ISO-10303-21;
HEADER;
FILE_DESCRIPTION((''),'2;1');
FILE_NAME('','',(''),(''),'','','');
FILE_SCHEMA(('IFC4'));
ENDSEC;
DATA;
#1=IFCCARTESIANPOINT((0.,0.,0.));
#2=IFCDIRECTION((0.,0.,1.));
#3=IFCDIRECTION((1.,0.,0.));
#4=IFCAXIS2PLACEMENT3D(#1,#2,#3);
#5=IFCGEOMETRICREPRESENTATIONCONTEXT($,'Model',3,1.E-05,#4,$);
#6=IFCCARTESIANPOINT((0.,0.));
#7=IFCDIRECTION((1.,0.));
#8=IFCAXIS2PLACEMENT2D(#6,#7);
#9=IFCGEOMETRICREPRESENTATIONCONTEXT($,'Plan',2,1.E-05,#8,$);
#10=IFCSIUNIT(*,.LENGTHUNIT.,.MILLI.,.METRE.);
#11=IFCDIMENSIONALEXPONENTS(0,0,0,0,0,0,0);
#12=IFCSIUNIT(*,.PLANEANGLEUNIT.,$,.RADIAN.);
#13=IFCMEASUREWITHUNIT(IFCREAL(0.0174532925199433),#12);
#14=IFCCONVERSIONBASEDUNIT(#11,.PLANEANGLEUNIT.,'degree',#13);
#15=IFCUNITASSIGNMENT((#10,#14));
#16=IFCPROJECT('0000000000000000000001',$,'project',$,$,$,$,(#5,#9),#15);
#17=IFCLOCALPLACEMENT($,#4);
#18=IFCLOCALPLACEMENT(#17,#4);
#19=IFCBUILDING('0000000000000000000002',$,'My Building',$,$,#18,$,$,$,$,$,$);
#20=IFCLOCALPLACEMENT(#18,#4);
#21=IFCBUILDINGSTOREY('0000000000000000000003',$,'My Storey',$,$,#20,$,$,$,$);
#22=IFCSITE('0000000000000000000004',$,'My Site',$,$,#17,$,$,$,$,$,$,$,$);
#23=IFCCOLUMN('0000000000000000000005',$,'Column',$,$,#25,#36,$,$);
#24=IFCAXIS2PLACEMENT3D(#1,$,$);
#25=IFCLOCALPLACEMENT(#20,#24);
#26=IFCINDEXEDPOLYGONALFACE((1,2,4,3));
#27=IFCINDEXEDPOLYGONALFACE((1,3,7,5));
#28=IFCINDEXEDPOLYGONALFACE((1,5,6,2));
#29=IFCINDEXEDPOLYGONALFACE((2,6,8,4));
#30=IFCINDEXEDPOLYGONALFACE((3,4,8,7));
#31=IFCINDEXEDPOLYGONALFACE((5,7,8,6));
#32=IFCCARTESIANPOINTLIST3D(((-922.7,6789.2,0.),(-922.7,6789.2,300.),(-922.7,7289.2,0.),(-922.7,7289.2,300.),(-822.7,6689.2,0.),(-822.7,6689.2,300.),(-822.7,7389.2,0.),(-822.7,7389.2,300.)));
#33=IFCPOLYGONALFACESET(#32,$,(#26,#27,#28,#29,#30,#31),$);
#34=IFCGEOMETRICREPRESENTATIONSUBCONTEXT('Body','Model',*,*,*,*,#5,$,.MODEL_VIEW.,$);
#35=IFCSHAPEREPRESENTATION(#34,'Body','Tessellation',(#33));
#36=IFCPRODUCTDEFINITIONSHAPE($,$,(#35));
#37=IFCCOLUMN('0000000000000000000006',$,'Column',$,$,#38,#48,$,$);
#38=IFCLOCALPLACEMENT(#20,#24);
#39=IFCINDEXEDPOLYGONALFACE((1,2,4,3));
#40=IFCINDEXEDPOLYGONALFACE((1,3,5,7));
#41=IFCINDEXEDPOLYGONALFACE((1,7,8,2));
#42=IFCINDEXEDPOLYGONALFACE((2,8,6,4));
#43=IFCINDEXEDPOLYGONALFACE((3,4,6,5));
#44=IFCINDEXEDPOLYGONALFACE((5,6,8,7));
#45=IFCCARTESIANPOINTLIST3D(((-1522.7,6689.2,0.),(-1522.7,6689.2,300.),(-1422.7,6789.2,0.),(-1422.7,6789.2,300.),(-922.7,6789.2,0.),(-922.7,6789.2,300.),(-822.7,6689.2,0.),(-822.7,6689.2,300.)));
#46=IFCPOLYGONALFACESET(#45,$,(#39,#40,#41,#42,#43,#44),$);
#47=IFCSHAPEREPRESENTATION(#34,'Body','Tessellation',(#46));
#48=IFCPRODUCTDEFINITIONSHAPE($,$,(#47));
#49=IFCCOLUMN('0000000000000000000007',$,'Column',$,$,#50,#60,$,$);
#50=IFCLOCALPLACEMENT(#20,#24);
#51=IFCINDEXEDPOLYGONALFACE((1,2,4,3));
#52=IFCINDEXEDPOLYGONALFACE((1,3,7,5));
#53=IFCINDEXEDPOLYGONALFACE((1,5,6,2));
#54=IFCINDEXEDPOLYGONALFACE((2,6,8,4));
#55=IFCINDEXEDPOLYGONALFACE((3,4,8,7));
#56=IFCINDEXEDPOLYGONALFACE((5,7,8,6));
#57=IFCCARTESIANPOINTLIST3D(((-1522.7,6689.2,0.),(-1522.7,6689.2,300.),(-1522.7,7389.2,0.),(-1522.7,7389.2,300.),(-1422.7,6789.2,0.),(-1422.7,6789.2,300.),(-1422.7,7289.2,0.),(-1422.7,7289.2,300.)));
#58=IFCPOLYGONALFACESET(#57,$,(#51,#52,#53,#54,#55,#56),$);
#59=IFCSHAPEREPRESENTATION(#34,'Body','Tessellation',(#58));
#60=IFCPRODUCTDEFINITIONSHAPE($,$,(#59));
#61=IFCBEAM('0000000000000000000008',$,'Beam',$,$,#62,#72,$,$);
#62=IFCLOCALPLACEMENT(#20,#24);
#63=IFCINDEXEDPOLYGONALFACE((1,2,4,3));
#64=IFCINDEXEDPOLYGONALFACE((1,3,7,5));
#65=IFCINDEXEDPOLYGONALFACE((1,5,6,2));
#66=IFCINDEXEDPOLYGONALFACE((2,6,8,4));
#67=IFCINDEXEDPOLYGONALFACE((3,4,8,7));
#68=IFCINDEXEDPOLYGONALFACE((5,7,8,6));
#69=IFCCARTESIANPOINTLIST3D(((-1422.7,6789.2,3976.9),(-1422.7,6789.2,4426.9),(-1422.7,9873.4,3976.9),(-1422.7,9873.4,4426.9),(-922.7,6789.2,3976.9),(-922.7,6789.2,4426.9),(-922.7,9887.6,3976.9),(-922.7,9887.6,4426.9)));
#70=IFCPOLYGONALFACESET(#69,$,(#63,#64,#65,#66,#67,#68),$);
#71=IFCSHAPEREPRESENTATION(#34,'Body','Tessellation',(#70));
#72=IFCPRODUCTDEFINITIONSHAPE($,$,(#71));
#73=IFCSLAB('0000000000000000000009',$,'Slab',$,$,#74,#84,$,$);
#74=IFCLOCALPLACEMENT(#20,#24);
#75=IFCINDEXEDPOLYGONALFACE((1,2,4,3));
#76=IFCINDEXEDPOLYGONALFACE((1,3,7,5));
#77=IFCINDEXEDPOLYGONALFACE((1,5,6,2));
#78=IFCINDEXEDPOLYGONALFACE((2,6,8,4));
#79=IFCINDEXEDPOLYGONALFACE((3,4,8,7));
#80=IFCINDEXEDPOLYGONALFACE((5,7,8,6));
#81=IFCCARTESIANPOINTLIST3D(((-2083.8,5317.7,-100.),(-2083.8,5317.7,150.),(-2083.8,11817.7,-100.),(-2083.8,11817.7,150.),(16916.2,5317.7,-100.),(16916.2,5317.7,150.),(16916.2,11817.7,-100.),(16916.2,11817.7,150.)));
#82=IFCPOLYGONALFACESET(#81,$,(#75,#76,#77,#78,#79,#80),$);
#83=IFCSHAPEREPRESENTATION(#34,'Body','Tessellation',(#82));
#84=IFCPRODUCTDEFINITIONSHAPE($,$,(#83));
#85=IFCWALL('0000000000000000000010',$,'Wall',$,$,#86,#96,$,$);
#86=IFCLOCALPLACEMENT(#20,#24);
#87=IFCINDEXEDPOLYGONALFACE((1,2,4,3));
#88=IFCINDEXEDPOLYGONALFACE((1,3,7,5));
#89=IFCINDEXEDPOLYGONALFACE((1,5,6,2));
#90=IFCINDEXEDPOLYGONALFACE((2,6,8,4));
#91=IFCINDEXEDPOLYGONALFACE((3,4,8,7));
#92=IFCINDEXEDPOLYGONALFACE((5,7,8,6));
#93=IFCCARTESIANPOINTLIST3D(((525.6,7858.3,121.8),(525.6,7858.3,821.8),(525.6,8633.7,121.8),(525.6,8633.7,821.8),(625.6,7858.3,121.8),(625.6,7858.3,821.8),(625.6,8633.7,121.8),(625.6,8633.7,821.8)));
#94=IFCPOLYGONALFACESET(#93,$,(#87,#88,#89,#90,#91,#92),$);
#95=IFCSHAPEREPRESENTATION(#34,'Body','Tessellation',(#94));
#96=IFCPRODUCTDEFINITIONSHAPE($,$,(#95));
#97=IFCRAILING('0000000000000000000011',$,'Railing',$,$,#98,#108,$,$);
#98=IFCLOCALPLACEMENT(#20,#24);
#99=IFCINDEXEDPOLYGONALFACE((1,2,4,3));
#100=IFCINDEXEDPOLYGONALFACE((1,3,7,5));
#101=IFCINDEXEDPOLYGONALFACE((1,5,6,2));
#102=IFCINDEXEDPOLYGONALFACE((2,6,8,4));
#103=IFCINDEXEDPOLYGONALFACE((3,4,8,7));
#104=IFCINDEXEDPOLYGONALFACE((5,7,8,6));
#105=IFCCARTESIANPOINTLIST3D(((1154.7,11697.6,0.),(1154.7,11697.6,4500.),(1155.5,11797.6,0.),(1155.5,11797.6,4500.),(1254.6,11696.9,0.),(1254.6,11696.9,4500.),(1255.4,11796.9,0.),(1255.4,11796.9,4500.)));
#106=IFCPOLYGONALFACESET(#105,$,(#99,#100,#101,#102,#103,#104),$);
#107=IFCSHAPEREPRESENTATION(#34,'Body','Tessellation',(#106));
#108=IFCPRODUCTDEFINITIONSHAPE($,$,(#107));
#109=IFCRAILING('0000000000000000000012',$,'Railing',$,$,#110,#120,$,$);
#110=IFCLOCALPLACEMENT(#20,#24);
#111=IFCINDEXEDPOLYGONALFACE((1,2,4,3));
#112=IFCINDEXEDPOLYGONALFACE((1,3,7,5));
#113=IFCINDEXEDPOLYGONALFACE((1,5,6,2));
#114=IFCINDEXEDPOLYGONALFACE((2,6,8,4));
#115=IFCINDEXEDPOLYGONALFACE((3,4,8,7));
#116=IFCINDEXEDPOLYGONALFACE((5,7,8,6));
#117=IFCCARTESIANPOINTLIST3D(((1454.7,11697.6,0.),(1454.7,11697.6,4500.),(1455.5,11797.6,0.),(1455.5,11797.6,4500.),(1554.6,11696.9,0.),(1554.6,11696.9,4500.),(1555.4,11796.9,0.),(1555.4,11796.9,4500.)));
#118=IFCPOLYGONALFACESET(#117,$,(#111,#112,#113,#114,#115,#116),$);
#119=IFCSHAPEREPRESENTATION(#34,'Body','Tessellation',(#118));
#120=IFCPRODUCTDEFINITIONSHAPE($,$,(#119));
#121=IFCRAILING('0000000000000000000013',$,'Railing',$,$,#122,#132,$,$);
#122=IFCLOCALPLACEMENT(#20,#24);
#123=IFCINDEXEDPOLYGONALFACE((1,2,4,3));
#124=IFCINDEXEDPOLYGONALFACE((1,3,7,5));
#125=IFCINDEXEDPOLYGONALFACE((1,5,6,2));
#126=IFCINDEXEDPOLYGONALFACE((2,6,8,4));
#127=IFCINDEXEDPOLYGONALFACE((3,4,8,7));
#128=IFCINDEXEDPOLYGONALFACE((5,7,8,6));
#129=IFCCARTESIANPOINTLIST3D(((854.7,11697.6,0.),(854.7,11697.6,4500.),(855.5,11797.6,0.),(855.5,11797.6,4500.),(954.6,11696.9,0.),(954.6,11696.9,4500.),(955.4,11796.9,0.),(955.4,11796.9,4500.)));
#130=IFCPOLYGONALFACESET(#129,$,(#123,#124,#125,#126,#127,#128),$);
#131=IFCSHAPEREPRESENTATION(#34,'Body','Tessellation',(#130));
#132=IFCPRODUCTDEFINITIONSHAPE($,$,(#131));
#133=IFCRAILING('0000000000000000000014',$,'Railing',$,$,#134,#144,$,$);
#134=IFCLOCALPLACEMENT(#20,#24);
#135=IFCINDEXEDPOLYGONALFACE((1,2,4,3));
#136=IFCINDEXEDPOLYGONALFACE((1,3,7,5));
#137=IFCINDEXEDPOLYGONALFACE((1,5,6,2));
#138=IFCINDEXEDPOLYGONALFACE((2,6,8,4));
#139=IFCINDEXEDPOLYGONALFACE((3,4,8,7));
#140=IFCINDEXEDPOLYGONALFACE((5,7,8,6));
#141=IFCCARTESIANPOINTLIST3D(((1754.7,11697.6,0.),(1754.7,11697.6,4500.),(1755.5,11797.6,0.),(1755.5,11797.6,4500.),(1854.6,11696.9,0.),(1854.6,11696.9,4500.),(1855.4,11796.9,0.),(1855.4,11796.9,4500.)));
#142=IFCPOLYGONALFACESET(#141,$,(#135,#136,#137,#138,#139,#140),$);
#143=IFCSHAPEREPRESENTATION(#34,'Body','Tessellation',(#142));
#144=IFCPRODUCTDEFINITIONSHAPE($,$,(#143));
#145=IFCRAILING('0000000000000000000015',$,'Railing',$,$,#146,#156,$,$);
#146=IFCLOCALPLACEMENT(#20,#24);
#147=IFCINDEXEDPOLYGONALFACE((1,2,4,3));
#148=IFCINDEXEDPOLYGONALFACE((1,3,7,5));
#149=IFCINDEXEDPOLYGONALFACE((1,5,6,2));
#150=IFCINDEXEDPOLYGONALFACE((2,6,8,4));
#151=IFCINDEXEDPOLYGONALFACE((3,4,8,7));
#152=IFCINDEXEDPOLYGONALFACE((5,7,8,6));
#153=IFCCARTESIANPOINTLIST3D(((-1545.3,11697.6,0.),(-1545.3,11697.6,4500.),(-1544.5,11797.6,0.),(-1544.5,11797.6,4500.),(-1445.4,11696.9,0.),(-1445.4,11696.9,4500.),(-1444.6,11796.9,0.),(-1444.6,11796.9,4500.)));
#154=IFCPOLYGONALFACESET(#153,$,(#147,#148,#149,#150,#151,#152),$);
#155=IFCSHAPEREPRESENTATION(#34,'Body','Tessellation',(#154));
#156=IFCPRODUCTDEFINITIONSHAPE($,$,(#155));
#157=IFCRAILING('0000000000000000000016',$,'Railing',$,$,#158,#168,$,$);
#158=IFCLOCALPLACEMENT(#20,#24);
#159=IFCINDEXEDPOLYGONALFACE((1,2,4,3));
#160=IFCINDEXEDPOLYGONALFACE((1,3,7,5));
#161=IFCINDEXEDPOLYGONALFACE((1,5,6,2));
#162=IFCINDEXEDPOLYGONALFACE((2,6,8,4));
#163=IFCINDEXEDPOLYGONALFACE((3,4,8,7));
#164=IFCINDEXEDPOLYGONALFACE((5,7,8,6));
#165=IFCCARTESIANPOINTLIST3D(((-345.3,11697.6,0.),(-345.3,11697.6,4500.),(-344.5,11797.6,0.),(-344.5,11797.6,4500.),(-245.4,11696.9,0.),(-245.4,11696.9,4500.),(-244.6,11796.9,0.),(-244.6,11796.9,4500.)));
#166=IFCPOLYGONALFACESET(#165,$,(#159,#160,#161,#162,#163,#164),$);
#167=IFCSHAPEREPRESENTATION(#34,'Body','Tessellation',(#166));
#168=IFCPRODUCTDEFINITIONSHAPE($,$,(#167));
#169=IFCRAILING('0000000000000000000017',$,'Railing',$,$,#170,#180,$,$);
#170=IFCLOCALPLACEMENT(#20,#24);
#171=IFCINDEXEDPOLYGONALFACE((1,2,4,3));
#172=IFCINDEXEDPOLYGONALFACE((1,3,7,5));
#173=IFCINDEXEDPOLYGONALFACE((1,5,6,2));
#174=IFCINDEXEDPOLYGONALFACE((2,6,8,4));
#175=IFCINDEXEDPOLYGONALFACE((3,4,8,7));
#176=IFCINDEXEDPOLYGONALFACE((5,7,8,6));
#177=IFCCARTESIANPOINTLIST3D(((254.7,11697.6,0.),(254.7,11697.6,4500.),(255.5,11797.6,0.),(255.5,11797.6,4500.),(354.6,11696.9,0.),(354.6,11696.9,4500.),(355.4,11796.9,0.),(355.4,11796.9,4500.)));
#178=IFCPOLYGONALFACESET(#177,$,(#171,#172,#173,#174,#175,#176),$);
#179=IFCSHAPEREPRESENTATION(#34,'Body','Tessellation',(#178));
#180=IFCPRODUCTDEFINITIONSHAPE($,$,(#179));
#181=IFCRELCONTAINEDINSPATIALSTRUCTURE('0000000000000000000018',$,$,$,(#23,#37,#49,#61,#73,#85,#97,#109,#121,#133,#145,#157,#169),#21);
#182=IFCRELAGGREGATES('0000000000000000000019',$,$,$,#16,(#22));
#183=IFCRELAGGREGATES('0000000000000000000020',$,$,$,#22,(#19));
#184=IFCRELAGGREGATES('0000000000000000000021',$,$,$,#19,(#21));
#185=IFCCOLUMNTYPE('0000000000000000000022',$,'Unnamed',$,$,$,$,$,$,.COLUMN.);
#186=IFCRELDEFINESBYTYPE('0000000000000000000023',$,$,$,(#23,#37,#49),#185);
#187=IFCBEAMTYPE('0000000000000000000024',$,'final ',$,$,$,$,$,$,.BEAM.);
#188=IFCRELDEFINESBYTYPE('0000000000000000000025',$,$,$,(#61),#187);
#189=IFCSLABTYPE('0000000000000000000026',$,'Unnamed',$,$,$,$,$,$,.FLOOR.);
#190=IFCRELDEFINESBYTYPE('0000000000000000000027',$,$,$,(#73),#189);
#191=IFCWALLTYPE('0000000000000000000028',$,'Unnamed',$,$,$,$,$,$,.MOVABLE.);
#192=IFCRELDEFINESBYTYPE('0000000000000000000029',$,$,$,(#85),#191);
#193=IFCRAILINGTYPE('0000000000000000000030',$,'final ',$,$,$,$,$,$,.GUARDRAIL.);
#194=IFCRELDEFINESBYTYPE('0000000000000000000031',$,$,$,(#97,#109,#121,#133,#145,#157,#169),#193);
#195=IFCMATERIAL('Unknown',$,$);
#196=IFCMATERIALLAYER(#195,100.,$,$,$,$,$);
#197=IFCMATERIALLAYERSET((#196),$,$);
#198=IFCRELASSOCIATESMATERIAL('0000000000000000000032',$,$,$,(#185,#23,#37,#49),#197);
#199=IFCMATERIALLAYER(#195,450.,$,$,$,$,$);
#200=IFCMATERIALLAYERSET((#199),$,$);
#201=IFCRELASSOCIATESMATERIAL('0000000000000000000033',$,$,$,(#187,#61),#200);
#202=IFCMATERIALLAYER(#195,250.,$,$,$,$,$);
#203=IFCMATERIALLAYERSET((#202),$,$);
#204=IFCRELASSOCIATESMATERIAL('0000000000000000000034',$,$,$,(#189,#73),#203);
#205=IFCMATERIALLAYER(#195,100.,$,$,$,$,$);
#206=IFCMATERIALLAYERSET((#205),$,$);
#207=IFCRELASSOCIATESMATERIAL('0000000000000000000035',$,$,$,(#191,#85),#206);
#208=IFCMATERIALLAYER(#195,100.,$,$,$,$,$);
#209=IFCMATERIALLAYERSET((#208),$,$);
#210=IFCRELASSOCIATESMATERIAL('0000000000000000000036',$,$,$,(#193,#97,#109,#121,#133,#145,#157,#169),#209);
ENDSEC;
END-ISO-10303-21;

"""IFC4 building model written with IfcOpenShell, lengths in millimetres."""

from ifc_helpers import new_model, entity, si_unit, converted_unit, frame, origin_with_axes, origin_2d_with_axis, place, context, subcontext, project, spatial, line, indexed_curve, outline, extrude, material, layer, layer_set, layer_usage, type_object, element, save


model = new_model("IFC4")

# Units and contexts
model_context = context("Model", 3, precision=1e-05, world=origin_with_axes())
plan_context = context("Plan", 2, precision=1e-05, world=origin_2d_with_axis())
body_context = subcontext(model_context, "Body", "Model", "MODEL_VIEW")
ifc_project = project(units=[si_unit("LENGTHUNIT", "METRE", prefix="MILLI"), converted_unit("PLANEANGLEUNIT", "degree", entity("IfcReal", 0.0174532925199433), si_unit("PLANEANGLEUNIT", "RADIAN"), dimensions=[0, 0, 0, 0, 0, 0, 0])], contexts=[model_context, plan_context])

# Site, building, storey
site_placement = place(None, origin_with_axes())
site = spatial("IfcSite", under=ifc_project, at=site_placement, Name="My Site")
building_placement = place(site_placement, origin_with_axes())
building = spatial("IfcBuilding", under=site, at=building_placement, Name="My Building")
storey_placement = place(building_placement, origin_with_axes())
storey = spatial("IfcBuildingStorey", under=building, at=storey_placement, Name="My Storey")

# Columns
ifc_material = material(Name="Unknown")
ifc_layer_1 = layer(ifc_material, 100.0)
ifc_layer_set_1 = layer_set([ifc_layer_1])
column_type = type_object("IfcColumnType", Name="Unnamed", PredefinedType="COLUMN", material=ifc_layer_set_1)
ifc_layer_usage_1 = layer_usage(ifc_layer_set_1, "AXIS2", "POSITIVE", 0.0)
column_1_placement = place(storey_placement, frame((-922.7, 7289.2, 0.0), z_axis=(0.0, 0.0, 1.0), x_axis=(0.0, -1.0, 0.0)))
element("IfcColumn", 1, at=column_1_placement, inside=storey, type_object=column_type, material=ifc_layer_usage_1, Name="Column", context=body_context, shape_type="SweptSolid", body=[
    extrude(outline(indexed_curve([(0.0, 0.0), (-100.0, 100.0), (600.0, 100.0), (500.0, 0.0)], segments=[line(1, 2, 3, 4, 1)])), origin_with_axes(), (0.0, 0.0, 1.0), 300.0),
])
ifc_layer_usage_2 = layer_usage(ifc_layer_set_1, "AXIS2", "POSITIVE", 0.0)
column_2_placement = place(storey_placement, frame((-922.7, 6789.2, 0.0), z_axis=(0.0, 0.0, 1.0), x_axis=(-1.0, 0.0, 0.0)))
element("IfcColumn", 2, at=column_2_placement, inside=storey, type_object=column_type, material=ifc_layer_usage_2, Name="Column", context=body_context, shape_type="SweptSolid", body=[
    extrude(outline(indexed_curve([(0.0, 0.0), (-100.0, 100.0), (600.0, 100.0), (500.0, 0.0)], segments=[line(1, 2, 3, 4, 1)])), origin_with_axes(), (0.0, 0.0, 1.0), 300.0),
])
ifc_layer_usage_3 = layer_usage(ifc_layer_set_1, "AXIS2", "POSITIVE", 0.0)
column_3_placement = place(storey_placement, frame((-1422.7, 6789.2, 0.0), z_axis=(0.0, 0.0, 1.0), x_axis=(0.0, 1.0, 0.0)))
element("IfcColumn", 3, at=column_3_placement, inside=storey, type_object=column_type, material=ifc_layer_usage_3, Name="Column", context=body_context, shape_type="SweptSolid", body=[
    extrude(outline(indexed_curve([(0.0, 0.0), (-100.0, 100.0), (600.0, 100.0), (500.0, 0.0)], segments=[line(1, 2, 3, 4, 1)])), origin_with_axes(), (0.0, 0.0, 1.0), 300.0),
])

# Beam
ifc_layer_2 = layer(ifc_material, 450.0)
ifc_layer_set_2 = layer_set([ifc_layer_2])
ifc_layer_usage_4 = layer_usage(ifc_layer_set_2, "AXIS3", "POSITIVE", -450.0)
beam_type_1 = type_object("IfcBeamType", Name="final ", PredefinedType="BEAM", material=ifc_layer_set_2)
beam_1_placement = place(storey_placement, frame((-922.7, 9887.6, 4426.9), z_axis=(0.0, 0.0, 1.0), x_axis=(1.0, 0.0, 0.0)))
element("IfcBeam", 4, at=beam_1_placement, inside=storey, type_object=beam_type_1, material=ifc_layer_usage_4, Name="Beam", context=body_context, shape_type="SweptSolid", body=[
    extrude(outline(indexed_curve([(0.0, 0.0), (0.0, -3098.3), (-500.0, -3098.3), (-500.0, -14.2), (0.0, 0.0)])), frame((0.0, 0.0, -450.0), z_axis=(0.0, 0.0, 1.0), x_axis=(1.0, 0.0, 0.0)), (0.0, 0.0, 1.0), 450.0),
])

# Slab
ifc_layer_3 = layer(ifc_material, 250.0)
ifc_layer_set_3 = layer_set([ifc_layer_3])
slab_type = type_object("IfcSlabType", Name="Unnamed", PredefinedType="FLOOR", material=ifc_layer_set_3)
ifc_layer_usage_5 = layer_usage(ifc_layer_set_3, "AXIS3", "POSITIVE", -100.0)
slab_1_placement = place(storey_placement, frame((-2083.8, 11817.7, 0.0), z_axis=(0.0, 0.0, 1.0), x_axis=(1.0, 0.0, 0.0)))
element("IfcSlab", 5, at=slab_1_placement, inside=storey, type_object=slab_type, material=ifc_layer_usage_5, Name="Slab", context=body_context, shape_type="SweptSolid", body=[
    extrude(outline(indexed_curve([(0.0, 0.0), (19000.0, 0.0), (19000.0, -6500.0), (0.0, -6500.0), (0.0, 0.0)])), frame((0.0, 0.0, -100.0), z_axis=(0.0, 0.0, 1.0), x_axis=(1.0, 0.0, 0.0)), (0.0, 0.0, 1.0), 250.0),
])

# Wall
ifc_layer_4 = layer(ifc_material, 100.0)
ifc_layer_set_4 = layer_set([ifc_layer_4])
ifc_layer_usage_6 = layer_usage(ifc_layer_set_4, "AXIS2", "POSITIVE", 0.0)
wall_type = type_object("IfcWallType", Name="Unnamed", PredefinedType="MOVABLE", material=ifc_layer_set_4)
wall_placement = place(storey_placement, frame((525.6, 8633.7, 121.8), z_axis=(0.0, 0.0, 1.0), x_axis=(0.0, -1.0, 0.0)))
element("IfcWall", 6, at=wall_placement, inside=storey, type_object=wall_type, material=ifc_layer_usage_6, Name="Wall", context=body_context, shape_type="SweptSolid", body=[
    extrude(outline(indexed_curve([(0.0, 0.0), (0.0, 100.0), (775.4, 100.0), (775.4, 0.0)], segments=[line(1, 2, 3, 4, 1)])), origin_with_axes(), (0.0, 0.0, 1.0), 700.0),
])

# Railings
ifc_layer_5 = layer(ifc_material, 100.0)
ifc_layer_set_5 = layer_set([ifc_layer_5])
ifc_layer_usage_7 = layer_usage(ifc_layer_set_5, "AXIS2", "POSITIVE", 0.0)
railing_type = type_object("IfcRailingType", Name="final ", PredefinedType="GUARDRAIL", material=ifc_layer_set_5)
railing_1_placement = place(storey_placement, frame((1255.4, 11796.9, 0.0), z_axis=(0.0, 0.0, 1.0), x_axis=(-0.99997, 0.007689, 0.0)))
element("IfcRailing", 7, at=railing_1_placement, inside=storey, type_object=railing_type, material=ifc_layer_usage_7, Name="Railing", context=body_context, shape_type="SweptSolid", body=[
    extrude(outline(indexed_curve([(0.0, 0.0), (0.0, 100.0), (99.8, 100.0), (99.8, 0.0)], segments=[line(1, 2, 3, 4, 1)])), origin_with_axes(), (0.0, 0.0, 1.0), 4500.0),
])
ifc_layer_usage_8 = layer_usage(ifc_layer_set_5, "AXIS2", "POSITIVE", 0.0)
railing_2_placement = place(storey_placement, frame((1555.4, 11796.9, 0.0), z_axis=(0.0, 0.0, 1.0), x_axis=(-0.99997, 0.007689, 0.0)))
element("IfcRailing", 8, at=railing_2_placement, inside=storey, type_object=railing_type, material=ifc_layer_usage_8, Name="Railing", context=body_context, shape_type="SweptSolid", body=[
    extrude(outline(indexed_curve([(0.0, 0.0), (0.0, 100.0), (99.8, 100.0), (99.8, 0.0)], segments=[line(1, 2, 3, 4, 1)])), origin_with_axes(), (0.0, 0.0, 1.0), 4500.0),
])
ifc_layer_usage_9 = layer_usage(ifc_layer_set_5, "AXIS2", "POSITIVE", 0.0)
railing_3_placement = place(storey_placement, frame((955.4, 11796.9, 0.0), z_axis=(0.0, 0.0, 1.0), x_axis=(-0.99997, 0.007689, 0.0)))
element("IfcRailing", 9, at=railing_3_placement, inside=storey, type_object=railing_type, material=ifc_layer_usage_9, Name="Railing", context=body_context, shape_type="SweptSolid", body=[
    extrude(outline(indexed_curve([(0.0, 0.0), (0.0, 100.0), (99.8, 100.0), (99.8, 0.0)], segments=[line(1, 2, 3, 4, 1)])), origin_with_axes(), (0.0, 0.0, 1.0), 4500.0),
])
ifc_layer_usage_10 = layer_usage(ifc_layer_set_5, "AXIS2", "POSITIVE", 0.0)
railing_4_placement = place(storey_placement, frame((1855.4, 11796.9, 0.0), z_axis=(0.0, 0.0, 1.0), x_axis=(-0.99997, 0.007689, 0.0)))
element("IfcRailing", 10, at=railing_4_placement, inside=storey, type_object=railing_type, material=ifc_layer_usage_10, Name="Railing", context=body_context, shape_type="SweptSolid", body=[
    extrude(outline(indexed_curve([(0.0, 0.0), (0.0, 100.0), (99.8, 100.0), (99.8, 0.0)], segments=[line(1, 2, 3, 4, 1)])), origin_with_axes(), (0.0, 0.0, 1.0), 4500.0),
])
ifc_layer_usage_11 = layer_usage(ifc_layer_set_5, "AXIS2", "POSITIVE", 0.0)
railing_5_placement = place(storey_placement, frame((-1444.6, 11796.9, 0.0), z_axis=(0.0, 0.0, 1.0), x_axis=(-0.99997, 0.007689, 0.0)))
element("IfcRailing", 11, at=railing_5_placement, inside=storey, type_object=railing_type, material=ifc_layer_usage_11, Name="Railing", context=body_context, shape_type="SweptSolid", body=[
    extrude(outline(indexed_curve([(0.0, 0.0), (0.0, 100.0), (99.8, 100.0), (99.8, 0.0)], segments=[line(1, 2, 3, 4, 1)])), origin_with_axes(), (0.0, 0.0, 1.0), 4500.0),
])
ifc_layer_usage_12 = layer_usage(ifc_layer_set_5, "AXIS2", "POSITIVE", 0.0)
railing_6_placement = place(storey_placement, frame((-244.6, 11796.9, 0.0), z_axis=(0.0, 0.0, 1.0), x_axis=(-0.99997, 0.007689, 0.0)))
element("IfcRailing", 12, at=railing_6_placement, inside=storey, type_object=railing_type, material=ifc_layer_usage_12, Name="Railing", context=body_context, shape_type="SweptSolid", body=[
    extrude(outline(indexed_curve([(0.0, 0.0), (0.0, 100.0), (99.8, 100.0), (99.8, 0.0)], segments=[line(1, 2, 3, 4, 1)])), origin_with_axes(), (0.0, 0.0, 1.0), 4500.0),
])
ifc_layer_usage_13 = layer_usage(ifc_layer_set_5, "AXIS2", "POSITIVE", 0.0)
railing_7_placement = place(storey_placement, frame((355.4, 11796.9, 0.0), z_axis=(0.0, 0.0, 1.0), x_axis=(-0.99997, 0.007689, 0.0)))
element("IfcRailing", 13, at=railing_7_placement, inside=storey, type_object=railing_type, material=ifc_layer_usage_13, Name="Railing", context=body_context, shape_type="SweptSolid", body=[
    extrude(outline(indexed_curve([(0.0, 0.0), (0.0, 100.0), (99.8, 100.0), (99.8, 0.0)], segments=[line(1, 2, 3, 4, 1)])), origin_with_axes(), (0.0, 0.0, 1.0), 4500.0),
])

save(model, "model.ifc")
